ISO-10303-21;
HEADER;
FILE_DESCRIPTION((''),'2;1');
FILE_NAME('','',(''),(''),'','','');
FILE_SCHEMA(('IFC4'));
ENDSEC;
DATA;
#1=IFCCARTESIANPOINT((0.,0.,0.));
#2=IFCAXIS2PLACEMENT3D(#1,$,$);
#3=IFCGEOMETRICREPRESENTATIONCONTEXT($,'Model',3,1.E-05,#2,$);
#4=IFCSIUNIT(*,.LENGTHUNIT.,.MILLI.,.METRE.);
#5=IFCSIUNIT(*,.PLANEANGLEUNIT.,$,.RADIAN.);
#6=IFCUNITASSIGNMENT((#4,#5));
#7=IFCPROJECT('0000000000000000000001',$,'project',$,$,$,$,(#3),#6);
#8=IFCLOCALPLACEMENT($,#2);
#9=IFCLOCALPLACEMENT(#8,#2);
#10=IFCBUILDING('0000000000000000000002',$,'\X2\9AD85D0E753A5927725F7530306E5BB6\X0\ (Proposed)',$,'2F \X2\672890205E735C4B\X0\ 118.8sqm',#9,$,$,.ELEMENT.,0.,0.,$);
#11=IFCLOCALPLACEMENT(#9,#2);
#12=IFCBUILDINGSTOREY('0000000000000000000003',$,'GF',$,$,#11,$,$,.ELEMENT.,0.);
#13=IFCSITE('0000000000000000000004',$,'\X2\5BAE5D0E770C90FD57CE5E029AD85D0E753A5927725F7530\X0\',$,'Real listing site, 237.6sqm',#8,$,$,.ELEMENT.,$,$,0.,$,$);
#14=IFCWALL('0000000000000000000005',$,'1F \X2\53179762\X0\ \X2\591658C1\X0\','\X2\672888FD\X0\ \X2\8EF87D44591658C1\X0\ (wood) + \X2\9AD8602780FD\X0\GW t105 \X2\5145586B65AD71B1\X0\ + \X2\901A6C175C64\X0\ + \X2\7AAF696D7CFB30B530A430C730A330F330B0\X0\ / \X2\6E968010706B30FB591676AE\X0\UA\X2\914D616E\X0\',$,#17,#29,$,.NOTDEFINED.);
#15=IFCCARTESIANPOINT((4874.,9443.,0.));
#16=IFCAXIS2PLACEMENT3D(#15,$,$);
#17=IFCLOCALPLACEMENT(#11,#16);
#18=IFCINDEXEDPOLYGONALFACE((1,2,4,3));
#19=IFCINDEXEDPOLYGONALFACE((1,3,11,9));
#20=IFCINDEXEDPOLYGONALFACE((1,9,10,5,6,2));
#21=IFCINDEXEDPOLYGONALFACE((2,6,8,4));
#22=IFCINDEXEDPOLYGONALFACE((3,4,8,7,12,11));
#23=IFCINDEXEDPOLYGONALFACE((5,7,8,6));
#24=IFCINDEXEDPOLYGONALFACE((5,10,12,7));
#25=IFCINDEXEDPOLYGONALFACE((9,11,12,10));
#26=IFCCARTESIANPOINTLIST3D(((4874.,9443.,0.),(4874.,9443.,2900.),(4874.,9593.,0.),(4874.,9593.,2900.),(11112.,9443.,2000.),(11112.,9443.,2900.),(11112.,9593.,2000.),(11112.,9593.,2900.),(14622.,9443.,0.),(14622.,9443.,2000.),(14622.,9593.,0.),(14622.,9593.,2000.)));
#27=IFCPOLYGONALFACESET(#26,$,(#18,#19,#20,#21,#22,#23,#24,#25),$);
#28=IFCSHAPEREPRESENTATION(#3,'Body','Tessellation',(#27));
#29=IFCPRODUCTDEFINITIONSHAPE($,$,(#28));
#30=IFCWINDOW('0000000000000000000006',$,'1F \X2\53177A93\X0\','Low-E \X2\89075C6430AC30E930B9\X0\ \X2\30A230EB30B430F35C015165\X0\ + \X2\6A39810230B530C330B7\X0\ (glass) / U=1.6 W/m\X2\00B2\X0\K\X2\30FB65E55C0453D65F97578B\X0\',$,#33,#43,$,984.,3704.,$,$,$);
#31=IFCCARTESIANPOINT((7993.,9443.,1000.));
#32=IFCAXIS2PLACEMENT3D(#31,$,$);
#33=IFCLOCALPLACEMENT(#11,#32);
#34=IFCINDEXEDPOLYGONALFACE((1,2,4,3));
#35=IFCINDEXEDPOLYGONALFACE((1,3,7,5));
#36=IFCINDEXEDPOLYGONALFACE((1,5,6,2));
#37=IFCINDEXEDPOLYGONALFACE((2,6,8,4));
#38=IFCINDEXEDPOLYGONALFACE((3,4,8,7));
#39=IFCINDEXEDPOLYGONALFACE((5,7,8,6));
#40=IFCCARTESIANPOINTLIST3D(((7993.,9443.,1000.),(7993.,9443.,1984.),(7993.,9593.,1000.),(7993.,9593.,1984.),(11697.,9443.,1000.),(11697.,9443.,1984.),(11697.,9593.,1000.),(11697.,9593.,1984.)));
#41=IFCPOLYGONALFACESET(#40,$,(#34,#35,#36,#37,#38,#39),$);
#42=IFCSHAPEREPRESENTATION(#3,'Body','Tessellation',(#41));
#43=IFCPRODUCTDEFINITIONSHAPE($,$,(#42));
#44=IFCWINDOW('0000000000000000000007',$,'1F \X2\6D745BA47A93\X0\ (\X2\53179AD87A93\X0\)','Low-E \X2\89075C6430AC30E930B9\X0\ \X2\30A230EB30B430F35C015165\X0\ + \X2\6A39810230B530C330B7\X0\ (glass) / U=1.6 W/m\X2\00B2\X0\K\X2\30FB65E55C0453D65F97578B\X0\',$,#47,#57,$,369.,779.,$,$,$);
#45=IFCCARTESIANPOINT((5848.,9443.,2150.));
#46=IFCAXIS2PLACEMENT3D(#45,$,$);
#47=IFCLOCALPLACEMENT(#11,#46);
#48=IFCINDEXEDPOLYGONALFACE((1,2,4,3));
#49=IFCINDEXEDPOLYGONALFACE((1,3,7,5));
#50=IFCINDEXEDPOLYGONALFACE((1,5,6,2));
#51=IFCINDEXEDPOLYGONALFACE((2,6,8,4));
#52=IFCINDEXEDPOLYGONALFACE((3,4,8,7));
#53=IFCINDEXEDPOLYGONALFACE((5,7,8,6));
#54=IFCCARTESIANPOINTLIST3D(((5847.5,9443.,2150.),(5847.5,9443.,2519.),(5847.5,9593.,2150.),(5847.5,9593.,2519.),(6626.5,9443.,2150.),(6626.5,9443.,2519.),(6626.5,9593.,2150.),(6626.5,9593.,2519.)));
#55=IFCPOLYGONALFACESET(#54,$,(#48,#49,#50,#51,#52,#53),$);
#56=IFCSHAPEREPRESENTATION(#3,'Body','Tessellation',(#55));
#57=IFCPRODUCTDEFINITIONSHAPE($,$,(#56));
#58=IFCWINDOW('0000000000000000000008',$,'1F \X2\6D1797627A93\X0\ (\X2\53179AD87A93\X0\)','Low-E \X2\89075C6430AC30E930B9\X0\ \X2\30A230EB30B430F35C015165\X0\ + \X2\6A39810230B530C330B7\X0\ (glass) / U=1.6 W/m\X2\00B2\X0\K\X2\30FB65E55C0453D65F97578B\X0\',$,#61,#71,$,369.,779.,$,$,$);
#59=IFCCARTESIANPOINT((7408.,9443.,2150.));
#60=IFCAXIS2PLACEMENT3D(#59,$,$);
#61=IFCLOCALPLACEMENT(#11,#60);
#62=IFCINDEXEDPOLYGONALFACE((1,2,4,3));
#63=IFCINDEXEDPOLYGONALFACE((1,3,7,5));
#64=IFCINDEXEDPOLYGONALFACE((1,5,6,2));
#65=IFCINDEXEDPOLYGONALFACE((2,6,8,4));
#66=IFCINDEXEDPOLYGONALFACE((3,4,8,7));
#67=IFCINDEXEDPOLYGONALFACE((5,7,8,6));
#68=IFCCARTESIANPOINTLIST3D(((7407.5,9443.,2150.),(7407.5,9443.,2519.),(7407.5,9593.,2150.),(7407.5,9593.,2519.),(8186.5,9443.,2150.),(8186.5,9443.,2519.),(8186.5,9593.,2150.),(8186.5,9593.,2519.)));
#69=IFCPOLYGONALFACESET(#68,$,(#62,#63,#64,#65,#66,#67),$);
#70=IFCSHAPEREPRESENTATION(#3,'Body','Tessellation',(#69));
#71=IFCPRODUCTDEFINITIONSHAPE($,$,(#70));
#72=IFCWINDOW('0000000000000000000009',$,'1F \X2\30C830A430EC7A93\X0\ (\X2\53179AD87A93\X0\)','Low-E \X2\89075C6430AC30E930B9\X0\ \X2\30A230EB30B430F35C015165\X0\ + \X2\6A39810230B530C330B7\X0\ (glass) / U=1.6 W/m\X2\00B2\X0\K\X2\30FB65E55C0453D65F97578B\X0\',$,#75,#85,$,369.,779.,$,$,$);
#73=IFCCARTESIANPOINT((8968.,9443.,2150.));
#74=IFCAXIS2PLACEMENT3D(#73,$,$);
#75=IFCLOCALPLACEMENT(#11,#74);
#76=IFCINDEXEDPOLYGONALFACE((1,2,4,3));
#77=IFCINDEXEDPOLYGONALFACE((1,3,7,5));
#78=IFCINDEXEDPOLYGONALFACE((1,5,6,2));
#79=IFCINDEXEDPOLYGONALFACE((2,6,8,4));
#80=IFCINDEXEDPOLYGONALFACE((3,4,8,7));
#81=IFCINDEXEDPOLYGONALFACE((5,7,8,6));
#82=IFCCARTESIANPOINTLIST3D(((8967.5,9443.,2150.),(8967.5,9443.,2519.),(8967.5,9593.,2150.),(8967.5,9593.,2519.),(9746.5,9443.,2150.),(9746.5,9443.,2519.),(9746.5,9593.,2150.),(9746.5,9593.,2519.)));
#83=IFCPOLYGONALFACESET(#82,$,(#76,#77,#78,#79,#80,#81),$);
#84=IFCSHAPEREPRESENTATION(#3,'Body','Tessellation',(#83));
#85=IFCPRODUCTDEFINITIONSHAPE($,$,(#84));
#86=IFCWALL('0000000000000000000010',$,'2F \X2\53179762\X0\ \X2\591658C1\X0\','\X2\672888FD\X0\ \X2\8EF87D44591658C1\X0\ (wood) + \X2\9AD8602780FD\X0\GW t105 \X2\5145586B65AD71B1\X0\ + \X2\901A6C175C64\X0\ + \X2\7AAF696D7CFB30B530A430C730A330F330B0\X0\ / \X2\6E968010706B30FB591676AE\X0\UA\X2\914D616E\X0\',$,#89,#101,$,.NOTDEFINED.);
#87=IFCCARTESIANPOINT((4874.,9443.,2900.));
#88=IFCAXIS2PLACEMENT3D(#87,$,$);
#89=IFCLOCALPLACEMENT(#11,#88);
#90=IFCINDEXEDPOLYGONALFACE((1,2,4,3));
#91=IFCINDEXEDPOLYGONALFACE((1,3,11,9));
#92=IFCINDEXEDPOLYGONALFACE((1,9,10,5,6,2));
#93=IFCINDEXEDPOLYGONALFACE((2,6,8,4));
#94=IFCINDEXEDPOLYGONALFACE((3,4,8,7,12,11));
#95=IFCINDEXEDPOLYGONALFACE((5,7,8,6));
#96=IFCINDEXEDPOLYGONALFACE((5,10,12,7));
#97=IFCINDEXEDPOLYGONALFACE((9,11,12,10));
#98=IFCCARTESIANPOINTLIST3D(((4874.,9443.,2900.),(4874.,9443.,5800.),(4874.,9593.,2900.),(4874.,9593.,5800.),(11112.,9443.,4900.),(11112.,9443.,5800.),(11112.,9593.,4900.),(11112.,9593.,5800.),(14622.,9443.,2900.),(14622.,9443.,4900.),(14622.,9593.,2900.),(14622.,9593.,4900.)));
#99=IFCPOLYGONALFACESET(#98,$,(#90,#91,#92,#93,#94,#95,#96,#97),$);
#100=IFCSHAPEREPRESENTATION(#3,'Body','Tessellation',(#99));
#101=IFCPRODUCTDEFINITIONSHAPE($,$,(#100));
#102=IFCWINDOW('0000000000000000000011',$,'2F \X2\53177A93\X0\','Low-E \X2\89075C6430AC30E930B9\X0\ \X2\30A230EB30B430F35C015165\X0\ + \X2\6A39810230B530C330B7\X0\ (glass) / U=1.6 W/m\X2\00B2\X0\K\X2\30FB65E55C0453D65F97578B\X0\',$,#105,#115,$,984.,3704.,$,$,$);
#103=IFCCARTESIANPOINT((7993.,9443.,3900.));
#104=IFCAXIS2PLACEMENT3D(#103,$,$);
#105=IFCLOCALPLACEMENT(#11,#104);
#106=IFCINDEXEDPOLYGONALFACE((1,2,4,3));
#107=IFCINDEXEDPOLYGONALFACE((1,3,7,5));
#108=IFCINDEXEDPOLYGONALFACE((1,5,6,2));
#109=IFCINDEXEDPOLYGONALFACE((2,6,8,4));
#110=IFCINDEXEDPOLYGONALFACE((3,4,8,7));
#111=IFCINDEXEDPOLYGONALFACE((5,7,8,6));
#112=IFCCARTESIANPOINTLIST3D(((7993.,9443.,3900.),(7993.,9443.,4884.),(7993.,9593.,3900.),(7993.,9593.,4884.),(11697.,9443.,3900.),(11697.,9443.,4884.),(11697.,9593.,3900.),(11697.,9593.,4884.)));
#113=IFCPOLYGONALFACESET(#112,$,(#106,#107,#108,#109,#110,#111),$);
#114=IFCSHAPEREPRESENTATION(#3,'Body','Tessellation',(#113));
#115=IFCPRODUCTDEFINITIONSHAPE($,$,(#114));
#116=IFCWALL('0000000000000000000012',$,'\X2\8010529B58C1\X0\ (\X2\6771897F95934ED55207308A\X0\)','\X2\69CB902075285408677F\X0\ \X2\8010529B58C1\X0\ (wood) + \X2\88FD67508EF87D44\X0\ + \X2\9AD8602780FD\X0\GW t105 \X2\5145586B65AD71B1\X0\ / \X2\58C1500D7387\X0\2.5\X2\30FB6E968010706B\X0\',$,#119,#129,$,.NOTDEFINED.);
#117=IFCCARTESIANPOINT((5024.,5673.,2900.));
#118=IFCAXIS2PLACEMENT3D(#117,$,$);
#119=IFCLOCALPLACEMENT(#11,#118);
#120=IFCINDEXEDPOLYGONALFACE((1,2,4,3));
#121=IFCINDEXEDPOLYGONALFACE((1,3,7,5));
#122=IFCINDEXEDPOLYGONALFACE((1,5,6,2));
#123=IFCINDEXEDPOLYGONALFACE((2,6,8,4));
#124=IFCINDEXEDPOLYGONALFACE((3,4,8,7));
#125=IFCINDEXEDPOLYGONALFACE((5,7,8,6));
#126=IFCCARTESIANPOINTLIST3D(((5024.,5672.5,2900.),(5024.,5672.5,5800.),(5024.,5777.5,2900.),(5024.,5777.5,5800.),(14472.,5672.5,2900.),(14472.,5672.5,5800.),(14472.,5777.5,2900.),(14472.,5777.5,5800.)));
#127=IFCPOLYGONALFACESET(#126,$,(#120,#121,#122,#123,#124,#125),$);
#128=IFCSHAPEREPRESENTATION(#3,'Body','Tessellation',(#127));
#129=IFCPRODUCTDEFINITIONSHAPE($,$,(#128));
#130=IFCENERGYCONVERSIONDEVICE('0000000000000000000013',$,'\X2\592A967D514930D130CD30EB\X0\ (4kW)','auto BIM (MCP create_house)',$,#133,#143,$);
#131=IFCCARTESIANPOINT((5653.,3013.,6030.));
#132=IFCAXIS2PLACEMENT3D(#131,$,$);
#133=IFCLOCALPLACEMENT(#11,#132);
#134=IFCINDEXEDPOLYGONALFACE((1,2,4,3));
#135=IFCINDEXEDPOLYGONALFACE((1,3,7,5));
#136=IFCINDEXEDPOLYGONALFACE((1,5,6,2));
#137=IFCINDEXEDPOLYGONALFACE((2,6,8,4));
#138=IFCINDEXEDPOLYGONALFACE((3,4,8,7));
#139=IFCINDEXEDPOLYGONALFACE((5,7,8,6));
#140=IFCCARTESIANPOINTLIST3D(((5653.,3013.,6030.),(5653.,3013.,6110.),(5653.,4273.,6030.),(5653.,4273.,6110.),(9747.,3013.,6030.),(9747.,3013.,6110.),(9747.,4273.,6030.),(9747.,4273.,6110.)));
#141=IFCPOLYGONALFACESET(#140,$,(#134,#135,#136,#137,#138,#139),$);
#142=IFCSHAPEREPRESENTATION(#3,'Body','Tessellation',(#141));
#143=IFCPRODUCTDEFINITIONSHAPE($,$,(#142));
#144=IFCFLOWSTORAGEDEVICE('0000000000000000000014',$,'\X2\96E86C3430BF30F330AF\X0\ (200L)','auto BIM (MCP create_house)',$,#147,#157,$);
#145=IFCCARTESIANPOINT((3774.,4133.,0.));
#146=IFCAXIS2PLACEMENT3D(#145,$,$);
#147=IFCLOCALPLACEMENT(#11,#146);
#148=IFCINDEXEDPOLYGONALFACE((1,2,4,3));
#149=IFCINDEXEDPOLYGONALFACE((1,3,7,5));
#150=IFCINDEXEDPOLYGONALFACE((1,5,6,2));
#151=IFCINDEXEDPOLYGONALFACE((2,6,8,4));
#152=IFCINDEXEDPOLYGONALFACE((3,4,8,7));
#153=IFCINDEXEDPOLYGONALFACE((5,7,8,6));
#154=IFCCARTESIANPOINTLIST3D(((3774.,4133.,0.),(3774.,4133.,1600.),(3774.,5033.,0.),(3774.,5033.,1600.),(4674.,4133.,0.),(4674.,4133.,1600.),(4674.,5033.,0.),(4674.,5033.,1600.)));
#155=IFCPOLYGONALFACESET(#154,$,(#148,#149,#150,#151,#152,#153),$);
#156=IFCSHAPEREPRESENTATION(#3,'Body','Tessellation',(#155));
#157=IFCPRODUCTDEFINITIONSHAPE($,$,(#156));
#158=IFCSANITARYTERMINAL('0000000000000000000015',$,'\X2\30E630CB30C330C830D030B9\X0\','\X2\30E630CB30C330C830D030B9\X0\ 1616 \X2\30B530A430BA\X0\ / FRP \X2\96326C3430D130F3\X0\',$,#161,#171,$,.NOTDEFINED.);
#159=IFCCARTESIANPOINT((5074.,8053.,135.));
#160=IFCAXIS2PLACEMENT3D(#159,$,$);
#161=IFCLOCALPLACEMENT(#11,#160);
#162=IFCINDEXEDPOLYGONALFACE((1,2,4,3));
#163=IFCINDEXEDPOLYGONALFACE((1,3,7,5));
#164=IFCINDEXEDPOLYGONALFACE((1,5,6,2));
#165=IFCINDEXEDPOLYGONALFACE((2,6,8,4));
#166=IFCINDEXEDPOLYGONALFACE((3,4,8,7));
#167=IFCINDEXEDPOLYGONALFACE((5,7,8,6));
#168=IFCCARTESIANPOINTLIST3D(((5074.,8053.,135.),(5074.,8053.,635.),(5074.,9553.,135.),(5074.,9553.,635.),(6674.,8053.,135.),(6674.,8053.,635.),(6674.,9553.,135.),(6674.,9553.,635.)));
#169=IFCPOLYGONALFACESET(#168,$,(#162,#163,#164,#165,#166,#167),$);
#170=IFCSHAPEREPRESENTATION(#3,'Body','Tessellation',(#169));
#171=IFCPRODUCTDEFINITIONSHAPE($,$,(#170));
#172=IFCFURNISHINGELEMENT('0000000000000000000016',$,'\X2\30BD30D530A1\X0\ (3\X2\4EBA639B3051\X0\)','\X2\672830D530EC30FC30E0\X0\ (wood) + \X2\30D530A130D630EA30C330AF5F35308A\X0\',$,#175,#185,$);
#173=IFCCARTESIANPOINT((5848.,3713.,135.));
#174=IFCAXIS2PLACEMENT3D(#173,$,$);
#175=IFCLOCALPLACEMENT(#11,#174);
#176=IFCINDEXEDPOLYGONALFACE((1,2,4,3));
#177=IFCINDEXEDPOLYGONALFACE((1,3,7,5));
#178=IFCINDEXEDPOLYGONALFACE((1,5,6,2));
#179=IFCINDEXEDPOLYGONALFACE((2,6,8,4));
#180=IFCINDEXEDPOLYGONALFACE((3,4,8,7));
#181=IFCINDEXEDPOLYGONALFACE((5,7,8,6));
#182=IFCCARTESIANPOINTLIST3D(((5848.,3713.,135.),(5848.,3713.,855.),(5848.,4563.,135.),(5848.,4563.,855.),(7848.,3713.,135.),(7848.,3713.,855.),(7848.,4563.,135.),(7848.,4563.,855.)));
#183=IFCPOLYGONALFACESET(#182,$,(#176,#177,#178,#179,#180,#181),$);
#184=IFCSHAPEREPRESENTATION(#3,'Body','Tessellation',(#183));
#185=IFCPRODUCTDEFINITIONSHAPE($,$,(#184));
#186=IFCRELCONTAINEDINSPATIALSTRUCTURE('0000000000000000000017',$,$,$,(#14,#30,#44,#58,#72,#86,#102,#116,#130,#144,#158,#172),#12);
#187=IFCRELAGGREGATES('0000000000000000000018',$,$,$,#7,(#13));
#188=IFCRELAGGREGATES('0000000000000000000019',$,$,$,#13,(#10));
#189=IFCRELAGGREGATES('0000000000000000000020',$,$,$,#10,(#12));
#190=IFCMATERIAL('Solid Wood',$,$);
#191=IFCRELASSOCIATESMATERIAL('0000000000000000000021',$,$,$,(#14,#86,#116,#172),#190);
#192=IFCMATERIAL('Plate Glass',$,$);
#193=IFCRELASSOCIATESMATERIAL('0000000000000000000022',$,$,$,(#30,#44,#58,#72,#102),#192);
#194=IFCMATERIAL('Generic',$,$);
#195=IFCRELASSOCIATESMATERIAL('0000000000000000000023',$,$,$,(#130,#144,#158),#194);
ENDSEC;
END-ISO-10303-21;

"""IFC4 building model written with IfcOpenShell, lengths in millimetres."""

from ifc_helpers import new_model, si_unit, frame, frame_2d, origin, place, context, project, spatial, rectangle, extrude, material, element, fill, save


model = new_model("IFC4")

# Units and contexts
model_context = context("Model", 3, precision=1e-05, world=origin())
ifc_project = project(units=[si_unit("LENGTHUNIT", "METRE", prefix="MILLI"), si_unit("PLANEANGLEUNIT", "RADIAN")], contexts=[model_context])

# Site, building, storey
site_placement = place(None, origin())
site = spatial("IfcSite", under=ifc_project, at=site_placement, Name="宮崎県都城市高崎町大牟田", ObjectType="Real listing site, 237.6sqm", CompositionType="ELEMENT", RefElevation=0.0)
building_placement = place(site_placement, origin())
building = spatial("IfcBuilding", under=site, at=building_placement, Name="高崎町大牟田の家 (Proposed)", ObjectType="2F 木造平屋 118.8sqm", CompositionType="ELEMENT", ElevationOfRefHeight=0.0, ElevationOfTerrain=0.0)
storey_placement = place(building_placement, origin())
storey = spatial("IfcBuildingStorey", under=building, at=storey_placement, Name="GF", CompositionType="ELEMENT", Elevation=0.0)

# Wall, openings, windows
ifc_material_1 = material(Name="Solid Wood")
wall_1_placement = place(storey_placement, frame((4874.0, 9443.0, 0.0)))
wall_1 = element("IfcWall", 1, at=wall_1_placement, inside=storey, material=ifc_material_1, Name="1F 北面 外壁", Description="木製 軸組外壁 (wood) + 高性能GW t105 充填断熱 + 通気層 + 窯業系サイディング / 準耐火・外皮UA配慮", PredefinedType="NOTDEFINED", context=model_context, shape_type="SweptSolid", body=[
    extrude(rectangle(XDim=9748.0, YDim=150.0, at=frame_2d((4874.0, 75.0))), frame((4874.0, 9443.0, 0.0)), (0.0, 0.0, 1.0), 2900.0),
])
opening_1_placement = place(storey_placement, frame((7993.0, 9443.0, 1000.0)))
opening_1 = element("IfcOpeningElement", 2, at=opening_1_placement, cuts=wall_1, PredefinedType="NOTDEFINED", context=model_context, shape_type="SweptSolid", body=[
    extrude(rectangle(XDim=3704.0, YDim=150.0, at=frame_2d((1852.0, 75.0))), frame((7993.0, 9443.0, 1000.0)), (0.0, 0.0, 1.0), 984.0),
])
opening_2_placement = place(storey_placement, frame((5848.0, 9443.0, 2150.0)))
opening_2 = element("IfcOpeningElement", 3, at=opening_2_placement, cuts=wall_1, PredefinedType="NOTDEFINED", context=model_context, shape_type="SweptSolid", body=[
    extrude(rectangle(XDim=779.0, YDim=150.0, at=frame_2d((389.0, 75.0))), frame((5848.0, 9443.0, 2150.0)), (0.0, 0.0, 1.0), 369.0),
])
opening_3_placement = place(storey_placement, frame((7408.0, 9443.0, 2150.0)))
opening_3 = element("IfcOpeningElement", 4, at=opening_3_placement, cuts=wall_1, PredefinedType="NOTDEFINED", context=model_context, shape_type="SweptSolid", body=[
    extrude(rectangle(XDim=779.0, YDim=150.0, at=frame_2d((389.0, 75.0))), frame((7408.0, 9443.0, 2150.0)), (0.0, 0.0, 1.0), 369.0),
])
opening_4_placement = place(storey_placement, frame((8968.0, 9443.0, 2150.0)))
opening_4 = element("IfcOpeningElement", 5, at=opening_4_placement, cuts=wall_1, PredefinedType="NOTDEFINED", context=model_context, shape_type="SweptSolid", body=[
    extrude(rectangle(XDim=779.0, YDim=150.0, at=frame_2d((389.0, 75.0))), frame((8968.0, 9443.0, 2150.0)), (0.0, 0.0, 1.0), 369.0),
])
ifc_material_2 = material(Name="Plate Glass")
window_1_placement = place(storey_placement, frame((7993.0, 9443.0, 1000.0)))
window_1 = element("IfcWindow", 6, at=window_1_placement, inside=storey, material=ifc_material_2, Name="1F 北窓", Description="Low-E 複層ガラス アルゴン封入 + 樹脂サッシ (glass) / U=1.6 W/m²K・日射取得型", OverallHeight=984.0, OverallWidth=3704.0, context=model_context, shape_type="SweptSolid", body=[
    extrude(rectangle(XDim=3704.0, YDim=150.0, at=frame_2d((1852.0, 75.0))), frame((7993.0, 9443.0, 1000.0)), (0.0, 0.0, 1.0), 984.0),
])
fill(opening_1, window_1)
window_2_placement = place(storey_placement, frame((5848.0, 9443.0, 2150.0)))
window_2 = element("IfcWindow", 7, at=window_2_placement, inside=storey, material=ifc_material_2, Name="1F 浴室窓 (北高窓)", Description="Low-E 複層ガラス アルゴン封入 + 樹脂サッシ (glass) / U=1.6 W/m²K・日射取得型", OverallHeight=369.0, OverallWidth=779.0, context=model_context, shape_type="SweptSolid", body=[
    extrude(rectangle(XDim=779.0, YDim=150.0, at=frame_2d((389.0, 75.0))), frame((5848.0, 9443.0, 2150.0)), (0.0, 0.0, 1.0), 369.0),
])
fill(opening_2, window_2)
window_3_placement = place(storey_placement, frame((7408.0, 9443.0, 2150.0)))
window_3 = element("IfcWindow", 8, at=window_3_placement, inside=storey, material=ifc_material_2, Name="1F 洗面窓 (北高窓)", Description="Low-E 複層ガラス アルゴン封入 + 樹脂サッシ (glass) / U=1.6 W/m²K・日射取得型", OverallHeight=369.0, OverallWidth=779.0, context=model_context, shape_type="SweptSolid", body=[
    extrude(rectangle(XDim=779.0, YDim=150.0, at=frame_2d((389.0, 75.0))), frame((7408.0, 9443.0, 2150.0)), (0.0, 0.0, 1.0), 369.0),
])
fill(opening_3, window_3)
window_4_placement = place(storey_placement, frame((8968.0, 9443.0, 2150.0)))
window_4 = element("IfcWindow", 9, at=window_4_placement, inside=storey, material=ifc_material_2, Name="1F トイレ窓 (北高窓)", Description="Low-E 複層ガラス アルゴン封入 + 樹脂サッシ (glass) / U=1.6 W/m²K・日射取得型", OverallHeight=369.0, OverallWidth=779.0, context=model_context, shape_type="SweptSolid", body=[
    extrude(rectangle(XDim=779.0, YDim=150.0, at=frame_2d((389.0, 75.0))), frame((8968.0, 9443.0, 2150.0)), (0.0, 0.0, 1.0), 369.0),
])
fill(opening_4, window_4)

# Wall, opening, window
wall_2_placement = place(storey_placement, frame((4874.0, 9443.0, 2900.0)))
wall_2 = element("IfcWall", 10, at=wall_2_placement, inside=storey, material=ifc_material_1, Name="2F 北面 外壁", Description="木製 軸組外壁 (wood) + 高性能GW t105 充填断熱 + 通気層 + 窯業系サイディング / 準耐火・外皮UA配慮", PredefinedType="NOTDEFINED", context=model_context, shape_type="SweptSolid", body=[
    extrude(rectangle(XDim=9748.0, YDim=150.0, at=frame_2d((4874.0, 75.0))), frame((4874.0, 9443.0, 2900.0)), (0.0, 0.0, 1.0), 2900.0),
])
opening_5_placement = place(storey_placement, frame((7993.0, 9443.0, 3900.0)))
opening_5 = element("IfcOpeningElement", 11, at=opening_5_placement, cuts=wall_2, PredefinedType="NOTDEFINED", context=model_context, shape_type="SweptSolid", body=[
    extrude(rectangle(XDim=3704.0, YDim=150.0, at=frame_2d((1852.0, 75.0))), frame((7993.0, 9443.0, 3900.0)), (0.0, 0.0, 1.0), 984.0),
])
window_5_placement = place(storey_placement, frame((7993.0, 9443.0, 3900.0)))
window_5 = element("IfcWindow", 12, at=window_5_placement, inside=storey, material=ifc_material_2, Name="2F 北窓", Description="Low-E 複層ガラス アルゴン封入 + 樹脂サッシ (glass) / U=1.6 W/m²K・日射取得型", OverallHeight=984.0, OverallWidth=3704.0, context=model_context, shape_type="SweptSolid", body=[
    extrude(rectangle(XDim=3704.0, YDim=150.0, at=frame_2d((1852.0, 75.0))), frame((7993.0, 9443.0, 3900.0)), (0.0, 0.0, 1.0), 984.0),
])
fill(opening_5, window_5)

# Wall
wall_3_placement = place(storey_placement, frame((5024.0, 5673.0, 2900.0)))
element("IfcWall", 13, at=wall_3_placement, inside=storey, material=ifc_material_1, Name="耐力壁 (東西間仕切り)", Description="構造用合板 耐力壁 (wood) + 製材軸組 + 高性能GW t105 充填断熱 / 壁倍率2.5・準耐火", PredefinedType="NOTDEFINED", context=model_context, shape_type="SweptSolid", body=[
    extrude(rectangle(XDim=9448.0, YDim=105.0, at=frame_2d((4724.0, 52.0))), frame((5024.0, 5673.0, 2900.0)), (0.0, 0.0, 1.0), 2900.0),
])

# Energy conversion device
ifc_material_3 = material(Name="Generic")
energy_conversion_device_placement = place(storey_placement, frame((5653.0, 3013.0, 6030.0)))
element("IfcEnergyConversionDevice", 14, at=energy_conversion_device_placement, inside=storey, material=ifc_material_3, Name="太陽光パネル (4kW)", Description="auto BIM (MCP create_house)", context=model_context, shape_type="SweptSolid", body=[
    extrude(rectangle(XDim=4094.0, YDim=1260.0, at=frame_2d((2047.0, 630.0))), frame((5653.0, 3013.0, 6030.0)), (0.0, 0.0, 1.0), 80.0),
])

# Flow storage device
flow_storage_device_placement = place(storey_placement, frame((3774.0, 4133.0, 0.0)))
element("IfcFlowStorageDevice", 15, at=flow_storage_device_placement, inside=storey, material=ifc_material_3, Name="雨水タンク (200L)", Description="auto BIM (MCP create_house)", context=model_context, shape_type="SweptSolid", body=[
    extrude(rectangle(XDim=900.0, YDim=900.0, at=frame_2d((450.0, 450.0))), frame((3774.0, 4133.0, 0.0)), (0.0, 0.0, 1.0), 1600.0),
])

# Sanitary terminal
sanitary_terminal_placement = place(storey_placement, frame((5074.0, 8053.0, 135.0)))
element("IfcSanitaryTerminal", 16, at=sanitary_terminal_placement, inside=storey, material=ifc_material_3, Name="ユニットバス", Description="ユニットバス 1616 サイズ / FRP 防水パン", PredefinedType="NOTDEFINED", context=model_context, shape_type="SweptSolid", body=[
    extrude(rectangle(XDim=1600.0, YDim=1500.0, at=frame_2d((800.0, 750.0))), frame((5074.0, 8053.0, 135.0)), (0.0, 0.0, 1.0), 500.0),
])

# Furnishing element
furnishing_1_placement = place(storey_placement, frame((5848.0, 3713.0, 135.0)))
element("IfcFurnishingElement", 17, at=furnishing_1_placement, inside=storey, material=ifc_material_1, Name="ソファ (3人掛け)", Description="木フレーム (wood) + ファブリック張り", context=model_context, shape_type="SweptSolid", body=[
    extrude(rectangle(XDim=2000.0, YDim=850.0, at=frame_2d((1000.0, 425.0))), frame((5848.0, 3713.0, 135.0)), (0.0, 0.0, 1.0), 720.0),
])

save(model, "model.ifc")
